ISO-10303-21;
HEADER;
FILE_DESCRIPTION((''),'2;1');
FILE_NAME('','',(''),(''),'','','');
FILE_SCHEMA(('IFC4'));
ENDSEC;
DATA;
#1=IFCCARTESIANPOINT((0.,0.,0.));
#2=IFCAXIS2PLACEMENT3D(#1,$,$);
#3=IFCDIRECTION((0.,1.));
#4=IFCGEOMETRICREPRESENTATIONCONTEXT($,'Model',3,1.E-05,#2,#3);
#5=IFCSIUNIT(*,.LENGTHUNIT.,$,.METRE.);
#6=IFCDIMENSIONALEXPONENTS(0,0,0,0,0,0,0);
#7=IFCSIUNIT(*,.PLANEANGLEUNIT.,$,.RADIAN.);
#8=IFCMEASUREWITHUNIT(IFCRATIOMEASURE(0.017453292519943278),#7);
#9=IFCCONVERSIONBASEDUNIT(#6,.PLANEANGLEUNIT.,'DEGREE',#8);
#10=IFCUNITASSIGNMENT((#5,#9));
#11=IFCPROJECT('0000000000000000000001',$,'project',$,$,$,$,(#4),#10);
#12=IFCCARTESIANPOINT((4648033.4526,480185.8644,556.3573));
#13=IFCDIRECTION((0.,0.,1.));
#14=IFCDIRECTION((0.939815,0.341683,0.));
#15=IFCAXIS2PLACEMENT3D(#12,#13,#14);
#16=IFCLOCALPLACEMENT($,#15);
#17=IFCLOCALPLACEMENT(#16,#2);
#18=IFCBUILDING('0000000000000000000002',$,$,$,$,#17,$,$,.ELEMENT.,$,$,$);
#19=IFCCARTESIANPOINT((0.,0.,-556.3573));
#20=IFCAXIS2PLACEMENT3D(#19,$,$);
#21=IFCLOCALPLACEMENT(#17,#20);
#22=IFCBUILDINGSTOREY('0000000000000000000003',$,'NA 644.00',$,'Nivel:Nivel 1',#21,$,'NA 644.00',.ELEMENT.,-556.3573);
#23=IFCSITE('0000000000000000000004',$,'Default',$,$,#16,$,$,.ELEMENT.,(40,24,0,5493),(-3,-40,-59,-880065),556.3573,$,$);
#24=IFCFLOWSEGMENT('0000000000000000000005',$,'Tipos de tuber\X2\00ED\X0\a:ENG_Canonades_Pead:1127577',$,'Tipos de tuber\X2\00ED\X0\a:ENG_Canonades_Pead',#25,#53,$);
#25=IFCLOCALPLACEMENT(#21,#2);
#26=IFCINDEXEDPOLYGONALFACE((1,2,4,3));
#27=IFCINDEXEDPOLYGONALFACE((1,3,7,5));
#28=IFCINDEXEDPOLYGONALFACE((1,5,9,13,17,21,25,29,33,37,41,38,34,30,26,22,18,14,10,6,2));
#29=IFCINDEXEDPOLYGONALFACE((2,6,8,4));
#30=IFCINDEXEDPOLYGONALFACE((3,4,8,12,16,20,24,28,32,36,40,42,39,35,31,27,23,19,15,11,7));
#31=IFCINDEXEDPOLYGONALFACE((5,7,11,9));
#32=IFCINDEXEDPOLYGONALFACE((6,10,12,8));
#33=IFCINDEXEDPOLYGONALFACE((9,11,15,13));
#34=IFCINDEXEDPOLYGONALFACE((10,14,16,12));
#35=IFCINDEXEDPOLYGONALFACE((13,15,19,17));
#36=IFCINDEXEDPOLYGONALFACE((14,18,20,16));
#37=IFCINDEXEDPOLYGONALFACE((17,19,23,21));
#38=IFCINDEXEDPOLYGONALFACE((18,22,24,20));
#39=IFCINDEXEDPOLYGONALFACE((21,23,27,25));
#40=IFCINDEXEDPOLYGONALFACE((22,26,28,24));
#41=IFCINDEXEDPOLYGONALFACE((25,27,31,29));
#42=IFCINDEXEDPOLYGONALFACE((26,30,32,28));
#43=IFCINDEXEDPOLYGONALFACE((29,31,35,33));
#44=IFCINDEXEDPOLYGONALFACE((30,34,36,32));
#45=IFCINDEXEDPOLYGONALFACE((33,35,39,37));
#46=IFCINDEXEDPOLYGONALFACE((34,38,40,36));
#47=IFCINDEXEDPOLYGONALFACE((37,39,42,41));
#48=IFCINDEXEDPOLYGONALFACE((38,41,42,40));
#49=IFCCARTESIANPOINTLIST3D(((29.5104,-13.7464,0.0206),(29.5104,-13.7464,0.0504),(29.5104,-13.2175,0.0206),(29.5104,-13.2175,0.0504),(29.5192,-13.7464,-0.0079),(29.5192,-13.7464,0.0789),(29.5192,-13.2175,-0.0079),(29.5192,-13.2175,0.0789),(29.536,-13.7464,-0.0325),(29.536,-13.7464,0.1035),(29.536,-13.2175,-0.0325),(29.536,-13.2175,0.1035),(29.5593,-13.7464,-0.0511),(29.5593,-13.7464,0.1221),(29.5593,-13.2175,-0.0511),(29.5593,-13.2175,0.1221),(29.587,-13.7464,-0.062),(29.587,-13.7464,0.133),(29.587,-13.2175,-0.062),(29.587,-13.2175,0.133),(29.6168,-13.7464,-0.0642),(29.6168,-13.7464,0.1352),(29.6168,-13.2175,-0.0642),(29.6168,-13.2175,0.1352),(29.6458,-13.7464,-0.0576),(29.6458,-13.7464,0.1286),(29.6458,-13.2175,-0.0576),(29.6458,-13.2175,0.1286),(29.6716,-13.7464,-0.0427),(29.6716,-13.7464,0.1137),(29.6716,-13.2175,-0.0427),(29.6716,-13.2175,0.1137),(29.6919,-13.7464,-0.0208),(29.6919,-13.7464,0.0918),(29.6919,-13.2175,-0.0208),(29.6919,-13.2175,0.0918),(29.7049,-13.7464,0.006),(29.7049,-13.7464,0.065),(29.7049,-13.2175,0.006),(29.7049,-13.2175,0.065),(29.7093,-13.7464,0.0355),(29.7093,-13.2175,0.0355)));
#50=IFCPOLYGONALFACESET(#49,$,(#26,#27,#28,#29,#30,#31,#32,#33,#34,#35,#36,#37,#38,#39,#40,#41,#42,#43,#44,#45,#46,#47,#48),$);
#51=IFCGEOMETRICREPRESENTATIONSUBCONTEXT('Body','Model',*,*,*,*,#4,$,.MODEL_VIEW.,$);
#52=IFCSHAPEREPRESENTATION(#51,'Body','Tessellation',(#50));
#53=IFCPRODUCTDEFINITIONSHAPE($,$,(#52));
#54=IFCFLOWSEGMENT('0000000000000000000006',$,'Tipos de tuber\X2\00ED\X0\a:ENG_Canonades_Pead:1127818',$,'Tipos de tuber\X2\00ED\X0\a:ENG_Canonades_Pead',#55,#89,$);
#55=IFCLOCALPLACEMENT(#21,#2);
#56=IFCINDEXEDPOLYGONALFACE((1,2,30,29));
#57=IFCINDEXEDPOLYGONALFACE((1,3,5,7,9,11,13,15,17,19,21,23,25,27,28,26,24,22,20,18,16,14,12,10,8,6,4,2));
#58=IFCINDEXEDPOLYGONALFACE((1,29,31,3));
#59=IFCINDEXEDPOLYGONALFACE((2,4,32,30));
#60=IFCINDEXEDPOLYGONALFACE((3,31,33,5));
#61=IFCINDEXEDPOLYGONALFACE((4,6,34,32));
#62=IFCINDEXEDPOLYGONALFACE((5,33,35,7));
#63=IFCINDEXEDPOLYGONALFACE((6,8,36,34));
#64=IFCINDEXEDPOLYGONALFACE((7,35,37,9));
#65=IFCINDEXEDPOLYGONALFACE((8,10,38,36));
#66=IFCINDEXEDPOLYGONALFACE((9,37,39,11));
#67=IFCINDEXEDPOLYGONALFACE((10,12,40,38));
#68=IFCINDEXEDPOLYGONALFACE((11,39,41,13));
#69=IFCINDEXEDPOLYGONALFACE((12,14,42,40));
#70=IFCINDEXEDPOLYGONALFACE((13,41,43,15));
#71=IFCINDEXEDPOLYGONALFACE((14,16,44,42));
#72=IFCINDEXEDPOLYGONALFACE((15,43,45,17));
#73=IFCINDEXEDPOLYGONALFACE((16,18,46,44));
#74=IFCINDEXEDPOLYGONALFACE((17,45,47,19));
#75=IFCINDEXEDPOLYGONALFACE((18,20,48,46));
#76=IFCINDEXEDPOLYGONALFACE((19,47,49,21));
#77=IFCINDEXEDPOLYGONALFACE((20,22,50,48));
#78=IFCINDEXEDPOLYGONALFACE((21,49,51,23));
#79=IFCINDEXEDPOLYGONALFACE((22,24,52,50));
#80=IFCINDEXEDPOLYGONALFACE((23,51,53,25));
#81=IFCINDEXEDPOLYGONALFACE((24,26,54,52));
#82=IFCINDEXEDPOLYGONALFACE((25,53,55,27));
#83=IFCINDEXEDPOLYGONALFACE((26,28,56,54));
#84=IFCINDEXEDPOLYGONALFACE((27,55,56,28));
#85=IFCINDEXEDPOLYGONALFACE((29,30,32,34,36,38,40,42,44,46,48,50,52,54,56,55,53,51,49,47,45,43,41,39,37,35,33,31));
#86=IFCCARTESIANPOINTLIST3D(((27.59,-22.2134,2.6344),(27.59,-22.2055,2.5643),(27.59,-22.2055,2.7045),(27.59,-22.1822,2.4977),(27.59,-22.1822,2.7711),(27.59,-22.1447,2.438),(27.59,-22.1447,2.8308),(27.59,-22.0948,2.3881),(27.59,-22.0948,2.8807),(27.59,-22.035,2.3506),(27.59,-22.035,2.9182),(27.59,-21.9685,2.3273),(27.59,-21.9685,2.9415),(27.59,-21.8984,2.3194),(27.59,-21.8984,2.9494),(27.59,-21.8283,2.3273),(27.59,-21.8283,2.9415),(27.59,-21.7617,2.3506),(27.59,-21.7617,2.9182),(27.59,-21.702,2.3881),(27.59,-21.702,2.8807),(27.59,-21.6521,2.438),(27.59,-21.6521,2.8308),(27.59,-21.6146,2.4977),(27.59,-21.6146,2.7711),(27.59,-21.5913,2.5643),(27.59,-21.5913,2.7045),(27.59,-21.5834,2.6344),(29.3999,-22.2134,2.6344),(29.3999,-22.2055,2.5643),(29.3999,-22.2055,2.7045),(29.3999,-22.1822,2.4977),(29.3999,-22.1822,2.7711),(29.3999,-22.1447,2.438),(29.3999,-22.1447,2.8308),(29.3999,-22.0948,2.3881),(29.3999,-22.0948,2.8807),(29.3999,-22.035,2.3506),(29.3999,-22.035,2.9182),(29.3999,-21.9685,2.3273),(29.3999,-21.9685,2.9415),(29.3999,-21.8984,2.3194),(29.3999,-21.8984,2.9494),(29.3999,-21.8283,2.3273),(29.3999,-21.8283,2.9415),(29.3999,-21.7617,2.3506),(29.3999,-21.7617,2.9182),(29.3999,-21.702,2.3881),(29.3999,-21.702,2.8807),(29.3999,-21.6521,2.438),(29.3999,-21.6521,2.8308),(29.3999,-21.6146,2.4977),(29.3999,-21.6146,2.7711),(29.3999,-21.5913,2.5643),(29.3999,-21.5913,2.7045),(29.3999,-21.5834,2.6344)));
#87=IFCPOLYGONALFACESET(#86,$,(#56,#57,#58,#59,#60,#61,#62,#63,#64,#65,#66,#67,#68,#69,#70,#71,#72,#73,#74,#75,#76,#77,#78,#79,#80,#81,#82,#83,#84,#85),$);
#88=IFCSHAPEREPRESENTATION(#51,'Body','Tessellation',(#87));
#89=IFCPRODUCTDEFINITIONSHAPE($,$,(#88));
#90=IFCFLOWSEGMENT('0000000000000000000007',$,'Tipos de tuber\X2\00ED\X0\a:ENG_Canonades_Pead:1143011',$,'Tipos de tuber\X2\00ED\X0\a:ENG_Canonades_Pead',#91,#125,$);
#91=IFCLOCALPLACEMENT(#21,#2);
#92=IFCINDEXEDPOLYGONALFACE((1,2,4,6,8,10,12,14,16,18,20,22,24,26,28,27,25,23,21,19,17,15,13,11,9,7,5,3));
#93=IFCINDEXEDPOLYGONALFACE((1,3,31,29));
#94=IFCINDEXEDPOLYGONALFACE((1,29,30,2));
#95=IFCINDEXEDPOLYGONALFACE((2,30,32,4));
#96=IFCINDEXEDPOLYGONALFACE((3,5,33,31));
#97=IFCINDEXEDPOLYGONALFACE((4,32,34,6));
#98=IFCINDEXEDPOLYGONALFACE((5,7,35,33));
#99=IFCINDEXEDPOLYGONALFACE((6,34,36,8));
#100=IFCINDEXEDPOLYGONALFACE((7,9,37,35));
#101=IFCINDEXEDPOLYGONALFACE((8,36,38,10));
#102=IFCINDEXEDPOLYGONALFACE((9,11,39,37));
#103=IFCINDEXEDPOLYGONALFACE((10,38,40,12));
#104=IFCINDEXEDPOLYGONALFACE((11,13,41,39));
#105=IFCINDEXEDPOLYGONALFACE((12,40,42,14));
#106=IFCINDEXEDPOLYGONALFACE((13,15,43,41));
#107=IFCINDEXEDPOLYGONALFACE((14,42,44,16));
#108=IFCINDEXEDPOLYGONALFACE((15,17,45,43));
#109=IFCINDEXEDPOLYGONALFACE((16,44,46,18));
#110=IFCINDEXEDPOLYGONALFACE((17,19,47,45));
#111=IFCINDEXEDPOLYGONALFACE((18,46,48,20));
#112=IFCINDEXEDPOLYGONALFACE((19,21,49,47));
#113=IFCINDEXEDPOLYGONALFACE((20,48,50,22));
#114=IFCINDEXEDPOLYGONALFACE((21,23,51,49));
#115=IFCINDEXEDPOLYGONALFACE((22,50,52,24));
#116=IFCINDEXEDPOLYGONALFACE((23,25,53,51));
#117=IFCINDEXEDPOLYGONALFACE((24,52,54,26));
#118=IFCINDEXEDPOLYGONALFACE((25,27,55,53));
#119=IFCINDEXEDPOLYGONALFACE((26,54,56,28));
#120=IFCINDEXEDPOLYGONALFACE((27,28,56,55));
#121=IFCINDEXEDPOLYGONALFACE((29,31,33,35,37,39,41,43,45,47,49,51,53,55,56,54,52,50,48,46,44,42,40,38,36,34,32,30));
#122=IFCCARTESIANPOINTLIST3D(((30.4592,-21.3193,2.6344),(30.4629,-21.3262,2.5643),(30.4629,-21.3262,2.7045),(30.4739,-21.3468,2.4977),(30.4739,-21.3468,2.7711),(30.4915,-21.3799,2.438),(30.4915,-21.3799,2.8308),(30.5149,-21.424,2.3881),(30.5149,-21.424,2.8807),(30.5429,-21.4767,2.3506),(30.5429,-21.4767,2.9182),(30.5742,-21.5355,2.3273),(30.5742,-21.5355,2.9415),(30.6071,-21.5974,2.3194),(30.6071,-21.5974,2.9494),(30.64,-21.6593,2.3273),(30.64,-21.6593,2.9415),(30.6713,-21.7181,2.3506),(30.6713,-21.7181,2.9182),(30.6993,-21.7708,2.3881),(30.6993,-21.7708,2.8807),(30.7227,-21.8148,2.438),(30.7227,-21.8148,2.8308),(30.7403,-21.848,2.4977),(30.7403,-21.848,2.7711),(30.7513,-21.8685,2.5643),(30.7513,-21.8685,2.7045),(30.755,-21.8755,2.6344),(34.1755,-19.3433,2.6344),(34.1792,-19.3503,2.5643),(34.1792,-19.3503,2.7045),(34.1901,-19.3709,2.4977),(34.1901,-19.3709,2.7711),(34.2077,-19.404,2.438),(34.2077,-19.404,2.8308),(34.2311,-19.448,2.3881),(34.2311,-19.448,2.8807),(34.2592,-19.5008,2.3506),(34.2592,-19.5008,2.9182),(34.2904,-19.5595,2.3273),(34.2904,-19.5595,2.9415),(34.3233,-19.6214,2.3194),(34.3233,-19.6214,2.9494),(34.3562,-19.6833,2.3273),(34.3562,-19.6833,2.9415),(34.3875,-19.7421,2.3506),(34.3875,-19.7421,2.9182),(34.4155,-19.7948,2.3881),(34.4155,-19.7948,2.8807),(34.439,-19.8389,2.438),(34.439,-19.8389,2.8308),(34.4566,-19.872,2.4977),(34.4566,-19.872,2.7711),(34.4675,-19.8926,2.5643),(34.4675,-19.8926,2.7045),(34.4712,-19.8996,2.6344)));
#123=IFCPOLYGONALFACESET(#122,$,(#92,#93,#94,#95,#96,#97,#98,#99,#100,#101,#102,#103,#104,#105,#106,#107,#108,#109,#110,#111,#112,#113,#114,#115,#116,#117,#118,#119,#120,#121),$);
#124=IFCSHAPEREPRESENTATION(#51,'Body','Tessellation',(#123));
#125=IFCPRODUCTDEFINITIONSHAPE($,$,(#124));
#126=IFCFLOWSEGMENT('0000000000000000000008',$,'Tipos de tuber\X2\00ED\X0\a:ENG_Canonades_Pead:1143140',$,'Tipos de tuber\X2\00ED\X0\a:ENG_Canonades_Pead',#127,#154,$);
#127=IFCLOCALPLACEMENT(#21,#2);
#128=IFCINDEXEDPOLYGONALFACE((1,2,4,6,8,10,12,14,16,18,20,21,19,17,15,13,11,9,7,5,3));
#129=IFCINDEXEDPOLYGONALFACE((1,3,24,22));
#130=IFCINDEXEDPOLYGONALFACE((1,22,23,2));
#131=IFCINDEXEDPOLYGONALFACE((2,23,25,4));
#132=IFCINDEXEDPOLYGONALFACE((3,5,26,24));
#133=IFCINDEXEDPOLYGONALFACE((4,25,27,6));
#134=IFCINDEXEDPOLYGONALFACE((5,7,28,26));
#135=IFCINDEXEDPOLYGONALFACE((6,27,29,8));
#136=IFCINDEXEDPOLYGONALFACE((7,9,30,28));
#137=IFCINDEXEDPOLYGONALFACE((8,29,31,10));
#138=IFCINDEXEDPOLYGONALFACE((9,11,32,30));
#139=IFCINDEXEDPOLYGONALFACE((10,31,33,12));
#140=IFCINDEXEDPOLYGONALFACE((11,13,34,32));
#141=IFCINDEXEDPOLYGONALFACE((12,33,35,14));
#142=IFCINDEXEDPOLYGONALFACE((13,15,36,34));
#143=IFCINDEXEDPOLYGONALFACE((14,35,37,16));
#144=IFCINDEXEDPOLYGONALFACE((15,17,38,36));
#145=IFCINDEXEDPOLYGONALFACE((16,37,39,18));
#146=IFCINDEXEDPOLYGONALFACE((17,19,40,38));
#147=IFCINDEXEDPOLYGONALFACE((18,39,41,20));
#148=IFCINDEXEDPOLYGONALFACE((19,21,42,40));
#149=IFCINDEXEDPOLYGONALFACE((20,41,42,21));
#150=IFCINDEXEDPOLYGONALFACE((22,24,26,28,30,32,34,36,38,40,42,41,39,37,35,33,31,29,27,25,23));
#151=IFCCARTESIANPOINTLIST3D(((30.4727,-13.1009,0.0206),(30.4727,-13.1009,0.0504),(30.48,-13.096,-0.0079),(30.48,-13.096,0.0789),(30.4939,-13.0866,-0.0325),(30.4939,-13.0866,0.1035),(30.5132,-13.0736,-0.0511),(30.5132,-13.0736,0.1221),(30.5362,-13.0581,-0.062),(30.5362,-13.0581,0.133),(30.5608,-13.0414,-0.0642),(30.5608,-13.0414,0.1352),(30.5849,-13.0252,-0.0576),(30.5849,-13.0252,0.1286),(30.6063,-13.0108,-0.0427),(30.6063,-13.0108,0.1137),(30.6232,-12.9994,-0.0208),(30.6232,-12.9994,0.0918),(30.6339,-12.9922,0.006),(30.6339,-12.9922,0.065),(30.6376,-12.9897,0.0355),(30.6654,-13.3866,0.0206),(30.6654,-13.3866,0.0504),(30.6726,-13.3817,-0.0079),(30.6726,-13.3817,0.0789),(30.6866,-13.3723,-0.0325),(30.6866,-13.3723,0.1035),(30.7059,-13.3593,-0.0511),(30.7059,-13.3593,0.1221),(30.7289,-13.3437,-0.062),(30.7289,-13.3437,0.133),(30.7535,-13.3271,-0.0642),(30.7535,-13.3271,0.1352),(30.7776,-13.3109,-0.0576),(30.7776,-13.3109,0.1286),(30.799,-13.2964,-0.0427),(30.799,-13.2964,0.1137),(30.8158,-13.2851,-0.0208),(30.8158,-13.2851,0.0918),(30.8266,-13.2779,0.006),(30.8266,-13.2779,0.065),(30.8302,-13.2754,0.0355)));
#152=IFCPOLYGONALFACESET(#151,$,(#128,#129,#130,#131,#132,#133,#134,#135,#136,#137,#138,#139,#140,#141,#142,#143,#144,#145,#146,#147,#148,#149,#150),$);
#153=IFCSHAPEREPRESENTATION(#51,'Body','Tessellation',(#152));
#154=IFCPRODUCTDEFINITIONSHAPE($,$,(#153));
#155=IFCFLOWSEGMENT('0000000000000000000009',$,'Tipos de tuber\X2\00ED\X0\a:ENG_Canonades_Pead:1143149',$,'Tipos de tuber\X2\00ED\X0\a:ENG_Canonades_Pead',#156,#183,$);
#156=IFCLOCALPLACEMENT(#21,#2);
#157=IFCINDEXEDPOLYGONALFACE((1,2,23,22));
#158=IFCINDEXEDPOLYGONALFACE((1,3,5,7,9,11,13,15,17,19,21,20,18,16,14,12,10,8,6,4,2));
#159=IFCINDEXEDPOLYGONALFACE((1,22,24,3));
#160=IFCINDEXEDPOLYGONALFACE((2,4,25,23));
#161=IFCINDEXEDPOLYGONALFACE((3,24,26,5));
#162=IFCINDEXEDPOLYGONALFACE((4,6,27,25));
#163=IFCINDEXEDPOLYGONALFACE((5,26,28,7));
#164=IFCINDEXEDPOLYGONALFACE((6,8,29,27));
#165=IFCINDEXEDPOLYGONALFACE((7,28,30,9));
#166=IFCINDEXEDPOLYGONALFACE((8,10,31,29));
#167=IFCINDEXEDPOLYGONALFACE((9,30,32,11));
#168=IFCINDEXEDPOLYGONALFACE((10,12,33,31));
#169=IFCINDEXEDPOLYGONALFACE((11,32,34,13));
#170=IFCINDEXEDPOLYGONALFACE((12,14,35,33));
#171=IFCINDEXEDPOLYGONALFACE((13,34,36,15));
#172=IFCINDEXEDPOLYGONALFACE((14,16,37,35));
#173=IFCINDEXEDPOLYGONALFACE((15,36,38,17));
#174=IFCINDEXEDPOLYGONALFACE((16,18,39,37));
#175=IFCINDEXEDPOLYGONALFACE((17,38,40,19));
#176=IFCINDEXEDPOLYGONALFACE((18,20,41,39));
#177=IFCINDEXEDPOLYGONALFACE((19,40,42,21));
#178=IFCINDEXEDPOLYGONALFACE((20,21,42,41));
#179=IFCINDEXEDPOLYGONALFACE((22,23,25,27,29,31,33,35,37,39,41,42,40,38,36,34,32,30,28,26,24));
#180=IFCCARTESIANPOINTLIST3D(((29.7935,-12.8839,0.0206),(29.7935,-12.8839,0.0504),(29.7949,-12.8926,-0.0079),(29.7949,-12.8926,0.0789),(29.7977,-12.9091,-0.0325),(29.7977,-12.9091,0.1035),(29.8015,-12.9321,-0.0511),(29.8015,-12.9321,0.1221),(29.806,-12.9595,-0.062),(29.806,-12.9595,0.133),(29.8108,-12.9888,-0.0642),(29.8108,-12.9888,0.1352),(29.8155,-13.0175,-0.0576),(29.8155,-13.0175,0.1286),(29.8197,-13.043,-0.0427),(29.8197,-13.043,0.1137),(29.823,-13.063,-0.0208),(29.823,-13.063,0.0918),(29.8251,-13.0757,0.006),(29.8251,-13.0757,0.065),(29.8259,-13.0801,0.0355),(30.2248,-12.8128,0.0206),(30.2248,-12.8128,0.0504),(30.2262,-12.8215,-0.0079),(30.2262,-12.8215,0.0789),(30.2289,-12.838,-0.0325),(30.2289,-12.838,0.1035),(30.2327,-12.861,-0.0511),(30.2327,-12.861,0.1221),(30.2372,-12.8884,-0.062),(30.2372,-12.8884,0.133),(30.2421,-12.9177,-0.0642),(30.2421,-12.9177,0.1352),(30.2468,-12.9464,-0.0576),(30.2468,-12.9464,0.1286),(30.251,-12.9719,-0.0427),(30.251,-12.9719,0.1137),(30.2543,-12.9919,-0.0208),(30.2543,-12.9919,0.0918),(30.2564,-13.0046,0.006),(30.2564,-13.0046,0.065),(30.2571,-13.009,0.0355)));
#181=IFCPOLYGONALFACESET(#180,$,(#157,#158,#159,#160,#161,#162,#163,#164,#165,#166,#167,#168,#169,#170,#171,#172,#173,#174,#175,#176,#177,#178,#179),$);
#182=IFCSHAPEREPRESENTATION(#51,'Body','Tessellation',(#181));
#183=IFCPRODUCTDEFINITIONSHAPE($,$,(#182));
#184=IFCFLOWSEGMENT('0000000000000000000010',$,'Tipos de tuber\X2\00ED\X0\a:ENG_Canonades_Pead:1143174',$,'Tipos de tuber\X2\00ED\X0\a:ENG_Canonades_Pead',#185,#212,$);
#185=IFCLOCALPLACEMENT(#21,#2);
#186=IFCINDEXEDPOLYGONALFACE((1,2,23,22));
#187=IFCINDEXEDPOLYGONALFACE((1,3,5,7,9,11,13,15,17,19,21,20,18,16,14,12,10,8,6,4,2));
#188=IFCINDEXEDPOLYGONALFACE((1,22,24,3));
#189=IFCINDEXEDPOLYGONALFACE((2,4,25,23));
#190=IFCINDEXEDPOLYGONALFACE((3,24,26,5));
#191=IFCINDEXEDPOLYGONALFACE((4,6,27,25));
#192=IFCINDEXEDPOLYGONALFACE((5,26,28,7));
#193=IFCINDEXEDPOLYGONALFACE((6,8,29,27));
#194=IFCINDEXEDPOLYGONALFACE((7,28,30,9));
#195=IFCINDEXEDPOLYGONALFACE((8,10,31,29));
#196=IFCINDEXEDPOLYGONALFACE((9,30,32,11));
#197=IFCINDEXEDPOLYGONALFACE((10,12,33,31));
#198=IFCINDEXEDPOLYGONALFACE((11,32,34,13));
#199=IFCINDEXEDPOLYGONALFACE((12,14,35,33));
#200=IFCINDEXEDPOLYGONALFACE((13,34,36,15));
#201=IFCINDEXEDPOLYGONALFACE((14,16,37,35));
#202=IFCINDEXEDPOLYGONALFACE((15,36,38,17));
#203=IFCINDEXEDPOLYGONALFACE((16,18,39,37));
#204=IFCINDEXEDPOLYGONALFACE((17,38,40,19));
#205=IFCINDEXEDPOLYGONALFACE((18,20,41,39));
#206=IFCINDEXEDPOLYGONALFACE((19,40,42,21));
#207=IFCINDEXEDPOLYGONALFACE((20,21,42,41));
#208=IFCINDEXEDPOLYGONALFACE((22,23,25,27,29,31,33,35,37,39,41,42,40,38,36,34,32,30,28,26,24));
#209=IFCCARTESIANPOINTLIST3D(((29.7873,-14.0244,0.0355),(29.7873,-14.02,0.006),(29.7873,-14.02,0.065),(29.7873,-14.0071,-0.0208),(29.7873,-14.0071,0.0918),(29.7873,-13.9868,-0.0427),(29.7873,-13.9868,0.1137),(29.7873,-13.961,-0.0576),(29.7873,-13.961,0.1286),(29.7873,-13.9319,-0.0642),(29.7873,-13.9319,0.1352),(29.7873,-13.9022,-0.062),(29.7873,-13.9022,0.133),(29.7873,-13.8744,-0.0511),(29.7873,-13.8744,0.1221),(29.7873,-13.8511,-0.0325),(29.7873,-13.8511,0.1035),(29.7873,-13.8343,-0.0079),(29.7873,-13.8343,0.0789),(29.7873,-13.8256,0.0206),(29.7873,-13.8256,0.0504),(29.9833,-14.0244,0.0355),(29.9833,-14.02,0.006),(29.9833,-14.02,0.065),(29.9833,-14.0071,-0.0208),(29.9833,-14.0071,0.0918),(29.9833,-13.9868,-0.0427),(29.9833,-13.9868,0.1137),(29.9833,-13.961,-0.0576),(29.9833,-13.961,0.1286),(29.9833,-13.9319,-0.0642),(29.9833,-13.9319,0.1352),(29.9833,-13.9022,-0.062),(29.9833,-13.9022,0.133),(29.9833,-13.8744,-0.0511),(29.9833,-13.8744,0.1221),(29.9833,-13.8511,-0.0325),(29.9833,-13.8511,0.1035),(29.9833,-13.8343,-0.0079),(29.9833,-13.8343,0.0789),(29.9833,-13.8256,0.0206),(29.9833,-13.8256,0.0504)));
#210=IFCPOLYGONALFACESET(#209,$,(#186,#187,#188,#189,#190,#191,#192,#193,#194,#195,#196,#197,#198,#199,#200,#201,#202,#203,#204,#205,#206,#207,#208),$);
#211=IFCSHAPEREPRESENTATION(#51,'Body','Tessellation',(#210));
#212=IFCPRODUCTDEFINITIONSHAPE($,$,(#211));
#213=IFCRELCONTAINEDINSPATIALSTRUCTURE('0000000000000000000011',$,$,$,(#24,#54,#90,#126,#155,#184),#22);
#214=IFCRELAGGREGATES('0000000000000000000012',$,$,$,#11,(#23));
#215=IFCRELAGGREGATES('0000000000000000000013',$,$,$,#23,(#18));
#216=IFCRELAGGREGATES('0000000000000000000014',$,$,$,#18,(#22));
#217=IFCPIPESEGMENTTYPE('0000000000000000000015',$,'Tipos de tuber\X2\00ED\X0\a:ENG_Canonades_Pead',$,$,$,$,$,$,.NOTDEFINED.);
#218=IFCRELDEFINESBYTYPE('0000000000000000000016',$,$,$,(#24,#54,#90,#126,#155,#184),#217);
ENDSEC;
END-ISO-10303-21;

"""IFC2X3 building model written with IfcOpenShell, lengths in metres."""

from ifc_helpers import new_model, entity, si_unit, converted_unit, direction, frame, frame_2d, origin, origin_2d_with_axis, place, context, subcontext, project, spatial, circle, extrude, type_object, element, save


model = new_model("IFC2X3")

# Units and contexts
model_context = context("Model", 3, precision=1e-05, world=origin(), true_north=direction((0.0, 1.0)))
body_context = subcontext(model_context, "Body", "Model", "MODEL_VIEW")
ifc_project = project(units=[si_unit("LENGTHUNIT", "METRE"), converted_unit("PLANEANGLEUNIT", "DEGREE", entity("IfcRatioMeasure", 0.017453292519943278), si_unit("PLANEANGLEUNIT", "RADIAN"), dimensions=[0, 0, 0, 0, 0, 0, 0])], contexts=[model_context])

# Site, building, storey
site_placement = place(None, frame((4648033.4526, 480185.8644, 556.3573), z_axis=(0.0, 0.0, 1.0), x_axis=(0.939815, 0.341683, 0.0)))
site = spatial("IfcSite", under=ifc_project, at=site_placement, Name="Default", CompositionType="ELEMENT", RefLatitude=(40, 24, 0, 5493), RefLongitude=(-3, -40, -59, -880065), RefElevation=556.3573)
building_placement = place(site_placement, origin())
building = spatial("IfcBuilding", under=site, at=building_placement, CompositionType="ELEMENT")
storey_placement = place(building_placement, frame((0.0, 0.0, -556.3573)))
storey = spatial("IfcBuildingStorey", under=building, at=storey_placement, Name="NA 644.00", ObjectType="Nivel:Nivel 1", LongName="NA 644.00", CompositionType="ELEMENT", Elevation=-556.3573)

# Flow segments
pipe_segment_type = type_object("IfcPipeSegmentType", Name="Tipos de tubería:ENG_Canonades_Pead", PredefinedType="NOTDEFINED")
flow_segment_1_placement = place(storey_placement, origin())
element("IfcFlowSegment", 1, at=flow_segment_1_placement, inside=storey, type_object=pipe_segment_type, Name="Tipos de tubería:ENG_Canonades_Pead:1127577", ObjectType="Tipos de tubería:ENG_Canonades_Pead", context=body_context, shape_type="SweptSolid", body=[
    extrude(circle(Radius=0.1, at=origin_2d_with_axis()), frame((29.6093, -13.7464, 0.0355), z_axis=(0.0, 1.0, 0.0), x_axis=(1.0, 0.0, 0.0)), (0.0, 0.0, 1.0), 0.529),
])
flow_segment_2_placement = place(storey_placement, origin())
element("IfcFlowSegment", 2, at=flow_segment_2_placement, inside=storey, type_object=pipe_segment_type, Name="Tipos de tubería:ENG_Canonades_Pead:1127818", ObjectType="Tipos de tubería:ENG_Canonades_Pead", context=body_context, shape_type="SweptSolid", body=[
    extrude(circle(Radius=0.315, at=origin_2d_with_axis()), frame((27.59, -21.8984, 2.6344), z_axis=(1.0, 0.0, 0.0), x_axis=(0.0, -1.0, 0.0)), (0.0, 0.0, 1.0), 1.8099),
])
flow_segment_3_placement = place(storey_placement, origin())
element("IfcFlowSegment", 3, at=flow_segment_3_placement, inside=storey, type_object=pipe_segment_type, Name="Tipos de tubería:ENG_Canonades_Pead:1143011", ObjectType="Tipos de tubería:ENG_Canonades_Pead", context=body_context, shape_type="SweptSolid", body=[
    extrude(circle(Radius=0.315, at=frame_2d((0.0, 0.0), x_axis=(1.0, 0.0))), frame((30.6071, -21.5974, 2.6344), z_axis=(0.882948, 0.469472, 0.000003), x_axis=(0.469472, -0.882948, 0.0)), (0.0, 0.0, 1.0), 4.2089),
])
flow_segment_4_placement = place(storey_placement, origin())
element("IfcFlowSegment", 4, at=flow_segment_4_placement, inside=storey, type_object=pipe_segment_type, Name="Tipos de tubería:ENG_Canonades_Pead:1143140", ObjectType="Tipos de tubería:ENG_Canonades_Pead", context=body_context, shape_type="SweptSolid", body=[
    extrude(circle(Radius=0.1, at=frame_2d((0.0, 0.0), x_axis=(1.0, 0.0))), frame((30.5547, -13.0456, 0.0355), z_axis=(0.559193, -0.829038, 0.0), x_axis=(0.829038, 0.559193, 0.0)), (0.0, 0.0, 1.0), 0.3446),
])
flow_segment_5_placement = place(storey_placement, origin())
element("IfcFlowSegment", 5, at=flow_segment_5_placement, inside=storey, type_object=pipe_segment_type, Name="Tipos de tubería:ENG_Canonades_Pead:1143149", ObjectType="Tipos de tubería:ENG_Canonades_Pead", context=body_context, shape_type="SweptSolid", body=[
    extrude(circle(Radius=0.1, at=origin_2d_with_axis()), frame((29.8096, -12.9815, 0.0355), z_axis=(0.98668, 0.162675, 0.0), x_axis=(0.162675, -0.98668, 0.0)), (0.0, 0.0, 1.0), 0.4371),
])
flow_segment_6_placement = place(storey_placement, origin())
element("IfcFlowSegment", 6, at=flow_segment_6_placement, inside=storey, type_object=pipe_segment_type, Name="Tipos de tubería:ENG_Canonades_Pead:1143174", ObjectType="Tipos de tubería:ENG_Canonades_Pead", context=body_context, shape_type="SweptSolid", body=[
    extrude(circle(Radius=0.1, at=origin_2d_with_axis()), frame((29.7873, -13.9244, 0.0355), z_axis=(1.0, 0.0, 0.0), x_axis=(0.0, -1.0, 0.0)), (0.0, 0.0, 1.0), 0.196),
])

save(model, "model.ifc")
